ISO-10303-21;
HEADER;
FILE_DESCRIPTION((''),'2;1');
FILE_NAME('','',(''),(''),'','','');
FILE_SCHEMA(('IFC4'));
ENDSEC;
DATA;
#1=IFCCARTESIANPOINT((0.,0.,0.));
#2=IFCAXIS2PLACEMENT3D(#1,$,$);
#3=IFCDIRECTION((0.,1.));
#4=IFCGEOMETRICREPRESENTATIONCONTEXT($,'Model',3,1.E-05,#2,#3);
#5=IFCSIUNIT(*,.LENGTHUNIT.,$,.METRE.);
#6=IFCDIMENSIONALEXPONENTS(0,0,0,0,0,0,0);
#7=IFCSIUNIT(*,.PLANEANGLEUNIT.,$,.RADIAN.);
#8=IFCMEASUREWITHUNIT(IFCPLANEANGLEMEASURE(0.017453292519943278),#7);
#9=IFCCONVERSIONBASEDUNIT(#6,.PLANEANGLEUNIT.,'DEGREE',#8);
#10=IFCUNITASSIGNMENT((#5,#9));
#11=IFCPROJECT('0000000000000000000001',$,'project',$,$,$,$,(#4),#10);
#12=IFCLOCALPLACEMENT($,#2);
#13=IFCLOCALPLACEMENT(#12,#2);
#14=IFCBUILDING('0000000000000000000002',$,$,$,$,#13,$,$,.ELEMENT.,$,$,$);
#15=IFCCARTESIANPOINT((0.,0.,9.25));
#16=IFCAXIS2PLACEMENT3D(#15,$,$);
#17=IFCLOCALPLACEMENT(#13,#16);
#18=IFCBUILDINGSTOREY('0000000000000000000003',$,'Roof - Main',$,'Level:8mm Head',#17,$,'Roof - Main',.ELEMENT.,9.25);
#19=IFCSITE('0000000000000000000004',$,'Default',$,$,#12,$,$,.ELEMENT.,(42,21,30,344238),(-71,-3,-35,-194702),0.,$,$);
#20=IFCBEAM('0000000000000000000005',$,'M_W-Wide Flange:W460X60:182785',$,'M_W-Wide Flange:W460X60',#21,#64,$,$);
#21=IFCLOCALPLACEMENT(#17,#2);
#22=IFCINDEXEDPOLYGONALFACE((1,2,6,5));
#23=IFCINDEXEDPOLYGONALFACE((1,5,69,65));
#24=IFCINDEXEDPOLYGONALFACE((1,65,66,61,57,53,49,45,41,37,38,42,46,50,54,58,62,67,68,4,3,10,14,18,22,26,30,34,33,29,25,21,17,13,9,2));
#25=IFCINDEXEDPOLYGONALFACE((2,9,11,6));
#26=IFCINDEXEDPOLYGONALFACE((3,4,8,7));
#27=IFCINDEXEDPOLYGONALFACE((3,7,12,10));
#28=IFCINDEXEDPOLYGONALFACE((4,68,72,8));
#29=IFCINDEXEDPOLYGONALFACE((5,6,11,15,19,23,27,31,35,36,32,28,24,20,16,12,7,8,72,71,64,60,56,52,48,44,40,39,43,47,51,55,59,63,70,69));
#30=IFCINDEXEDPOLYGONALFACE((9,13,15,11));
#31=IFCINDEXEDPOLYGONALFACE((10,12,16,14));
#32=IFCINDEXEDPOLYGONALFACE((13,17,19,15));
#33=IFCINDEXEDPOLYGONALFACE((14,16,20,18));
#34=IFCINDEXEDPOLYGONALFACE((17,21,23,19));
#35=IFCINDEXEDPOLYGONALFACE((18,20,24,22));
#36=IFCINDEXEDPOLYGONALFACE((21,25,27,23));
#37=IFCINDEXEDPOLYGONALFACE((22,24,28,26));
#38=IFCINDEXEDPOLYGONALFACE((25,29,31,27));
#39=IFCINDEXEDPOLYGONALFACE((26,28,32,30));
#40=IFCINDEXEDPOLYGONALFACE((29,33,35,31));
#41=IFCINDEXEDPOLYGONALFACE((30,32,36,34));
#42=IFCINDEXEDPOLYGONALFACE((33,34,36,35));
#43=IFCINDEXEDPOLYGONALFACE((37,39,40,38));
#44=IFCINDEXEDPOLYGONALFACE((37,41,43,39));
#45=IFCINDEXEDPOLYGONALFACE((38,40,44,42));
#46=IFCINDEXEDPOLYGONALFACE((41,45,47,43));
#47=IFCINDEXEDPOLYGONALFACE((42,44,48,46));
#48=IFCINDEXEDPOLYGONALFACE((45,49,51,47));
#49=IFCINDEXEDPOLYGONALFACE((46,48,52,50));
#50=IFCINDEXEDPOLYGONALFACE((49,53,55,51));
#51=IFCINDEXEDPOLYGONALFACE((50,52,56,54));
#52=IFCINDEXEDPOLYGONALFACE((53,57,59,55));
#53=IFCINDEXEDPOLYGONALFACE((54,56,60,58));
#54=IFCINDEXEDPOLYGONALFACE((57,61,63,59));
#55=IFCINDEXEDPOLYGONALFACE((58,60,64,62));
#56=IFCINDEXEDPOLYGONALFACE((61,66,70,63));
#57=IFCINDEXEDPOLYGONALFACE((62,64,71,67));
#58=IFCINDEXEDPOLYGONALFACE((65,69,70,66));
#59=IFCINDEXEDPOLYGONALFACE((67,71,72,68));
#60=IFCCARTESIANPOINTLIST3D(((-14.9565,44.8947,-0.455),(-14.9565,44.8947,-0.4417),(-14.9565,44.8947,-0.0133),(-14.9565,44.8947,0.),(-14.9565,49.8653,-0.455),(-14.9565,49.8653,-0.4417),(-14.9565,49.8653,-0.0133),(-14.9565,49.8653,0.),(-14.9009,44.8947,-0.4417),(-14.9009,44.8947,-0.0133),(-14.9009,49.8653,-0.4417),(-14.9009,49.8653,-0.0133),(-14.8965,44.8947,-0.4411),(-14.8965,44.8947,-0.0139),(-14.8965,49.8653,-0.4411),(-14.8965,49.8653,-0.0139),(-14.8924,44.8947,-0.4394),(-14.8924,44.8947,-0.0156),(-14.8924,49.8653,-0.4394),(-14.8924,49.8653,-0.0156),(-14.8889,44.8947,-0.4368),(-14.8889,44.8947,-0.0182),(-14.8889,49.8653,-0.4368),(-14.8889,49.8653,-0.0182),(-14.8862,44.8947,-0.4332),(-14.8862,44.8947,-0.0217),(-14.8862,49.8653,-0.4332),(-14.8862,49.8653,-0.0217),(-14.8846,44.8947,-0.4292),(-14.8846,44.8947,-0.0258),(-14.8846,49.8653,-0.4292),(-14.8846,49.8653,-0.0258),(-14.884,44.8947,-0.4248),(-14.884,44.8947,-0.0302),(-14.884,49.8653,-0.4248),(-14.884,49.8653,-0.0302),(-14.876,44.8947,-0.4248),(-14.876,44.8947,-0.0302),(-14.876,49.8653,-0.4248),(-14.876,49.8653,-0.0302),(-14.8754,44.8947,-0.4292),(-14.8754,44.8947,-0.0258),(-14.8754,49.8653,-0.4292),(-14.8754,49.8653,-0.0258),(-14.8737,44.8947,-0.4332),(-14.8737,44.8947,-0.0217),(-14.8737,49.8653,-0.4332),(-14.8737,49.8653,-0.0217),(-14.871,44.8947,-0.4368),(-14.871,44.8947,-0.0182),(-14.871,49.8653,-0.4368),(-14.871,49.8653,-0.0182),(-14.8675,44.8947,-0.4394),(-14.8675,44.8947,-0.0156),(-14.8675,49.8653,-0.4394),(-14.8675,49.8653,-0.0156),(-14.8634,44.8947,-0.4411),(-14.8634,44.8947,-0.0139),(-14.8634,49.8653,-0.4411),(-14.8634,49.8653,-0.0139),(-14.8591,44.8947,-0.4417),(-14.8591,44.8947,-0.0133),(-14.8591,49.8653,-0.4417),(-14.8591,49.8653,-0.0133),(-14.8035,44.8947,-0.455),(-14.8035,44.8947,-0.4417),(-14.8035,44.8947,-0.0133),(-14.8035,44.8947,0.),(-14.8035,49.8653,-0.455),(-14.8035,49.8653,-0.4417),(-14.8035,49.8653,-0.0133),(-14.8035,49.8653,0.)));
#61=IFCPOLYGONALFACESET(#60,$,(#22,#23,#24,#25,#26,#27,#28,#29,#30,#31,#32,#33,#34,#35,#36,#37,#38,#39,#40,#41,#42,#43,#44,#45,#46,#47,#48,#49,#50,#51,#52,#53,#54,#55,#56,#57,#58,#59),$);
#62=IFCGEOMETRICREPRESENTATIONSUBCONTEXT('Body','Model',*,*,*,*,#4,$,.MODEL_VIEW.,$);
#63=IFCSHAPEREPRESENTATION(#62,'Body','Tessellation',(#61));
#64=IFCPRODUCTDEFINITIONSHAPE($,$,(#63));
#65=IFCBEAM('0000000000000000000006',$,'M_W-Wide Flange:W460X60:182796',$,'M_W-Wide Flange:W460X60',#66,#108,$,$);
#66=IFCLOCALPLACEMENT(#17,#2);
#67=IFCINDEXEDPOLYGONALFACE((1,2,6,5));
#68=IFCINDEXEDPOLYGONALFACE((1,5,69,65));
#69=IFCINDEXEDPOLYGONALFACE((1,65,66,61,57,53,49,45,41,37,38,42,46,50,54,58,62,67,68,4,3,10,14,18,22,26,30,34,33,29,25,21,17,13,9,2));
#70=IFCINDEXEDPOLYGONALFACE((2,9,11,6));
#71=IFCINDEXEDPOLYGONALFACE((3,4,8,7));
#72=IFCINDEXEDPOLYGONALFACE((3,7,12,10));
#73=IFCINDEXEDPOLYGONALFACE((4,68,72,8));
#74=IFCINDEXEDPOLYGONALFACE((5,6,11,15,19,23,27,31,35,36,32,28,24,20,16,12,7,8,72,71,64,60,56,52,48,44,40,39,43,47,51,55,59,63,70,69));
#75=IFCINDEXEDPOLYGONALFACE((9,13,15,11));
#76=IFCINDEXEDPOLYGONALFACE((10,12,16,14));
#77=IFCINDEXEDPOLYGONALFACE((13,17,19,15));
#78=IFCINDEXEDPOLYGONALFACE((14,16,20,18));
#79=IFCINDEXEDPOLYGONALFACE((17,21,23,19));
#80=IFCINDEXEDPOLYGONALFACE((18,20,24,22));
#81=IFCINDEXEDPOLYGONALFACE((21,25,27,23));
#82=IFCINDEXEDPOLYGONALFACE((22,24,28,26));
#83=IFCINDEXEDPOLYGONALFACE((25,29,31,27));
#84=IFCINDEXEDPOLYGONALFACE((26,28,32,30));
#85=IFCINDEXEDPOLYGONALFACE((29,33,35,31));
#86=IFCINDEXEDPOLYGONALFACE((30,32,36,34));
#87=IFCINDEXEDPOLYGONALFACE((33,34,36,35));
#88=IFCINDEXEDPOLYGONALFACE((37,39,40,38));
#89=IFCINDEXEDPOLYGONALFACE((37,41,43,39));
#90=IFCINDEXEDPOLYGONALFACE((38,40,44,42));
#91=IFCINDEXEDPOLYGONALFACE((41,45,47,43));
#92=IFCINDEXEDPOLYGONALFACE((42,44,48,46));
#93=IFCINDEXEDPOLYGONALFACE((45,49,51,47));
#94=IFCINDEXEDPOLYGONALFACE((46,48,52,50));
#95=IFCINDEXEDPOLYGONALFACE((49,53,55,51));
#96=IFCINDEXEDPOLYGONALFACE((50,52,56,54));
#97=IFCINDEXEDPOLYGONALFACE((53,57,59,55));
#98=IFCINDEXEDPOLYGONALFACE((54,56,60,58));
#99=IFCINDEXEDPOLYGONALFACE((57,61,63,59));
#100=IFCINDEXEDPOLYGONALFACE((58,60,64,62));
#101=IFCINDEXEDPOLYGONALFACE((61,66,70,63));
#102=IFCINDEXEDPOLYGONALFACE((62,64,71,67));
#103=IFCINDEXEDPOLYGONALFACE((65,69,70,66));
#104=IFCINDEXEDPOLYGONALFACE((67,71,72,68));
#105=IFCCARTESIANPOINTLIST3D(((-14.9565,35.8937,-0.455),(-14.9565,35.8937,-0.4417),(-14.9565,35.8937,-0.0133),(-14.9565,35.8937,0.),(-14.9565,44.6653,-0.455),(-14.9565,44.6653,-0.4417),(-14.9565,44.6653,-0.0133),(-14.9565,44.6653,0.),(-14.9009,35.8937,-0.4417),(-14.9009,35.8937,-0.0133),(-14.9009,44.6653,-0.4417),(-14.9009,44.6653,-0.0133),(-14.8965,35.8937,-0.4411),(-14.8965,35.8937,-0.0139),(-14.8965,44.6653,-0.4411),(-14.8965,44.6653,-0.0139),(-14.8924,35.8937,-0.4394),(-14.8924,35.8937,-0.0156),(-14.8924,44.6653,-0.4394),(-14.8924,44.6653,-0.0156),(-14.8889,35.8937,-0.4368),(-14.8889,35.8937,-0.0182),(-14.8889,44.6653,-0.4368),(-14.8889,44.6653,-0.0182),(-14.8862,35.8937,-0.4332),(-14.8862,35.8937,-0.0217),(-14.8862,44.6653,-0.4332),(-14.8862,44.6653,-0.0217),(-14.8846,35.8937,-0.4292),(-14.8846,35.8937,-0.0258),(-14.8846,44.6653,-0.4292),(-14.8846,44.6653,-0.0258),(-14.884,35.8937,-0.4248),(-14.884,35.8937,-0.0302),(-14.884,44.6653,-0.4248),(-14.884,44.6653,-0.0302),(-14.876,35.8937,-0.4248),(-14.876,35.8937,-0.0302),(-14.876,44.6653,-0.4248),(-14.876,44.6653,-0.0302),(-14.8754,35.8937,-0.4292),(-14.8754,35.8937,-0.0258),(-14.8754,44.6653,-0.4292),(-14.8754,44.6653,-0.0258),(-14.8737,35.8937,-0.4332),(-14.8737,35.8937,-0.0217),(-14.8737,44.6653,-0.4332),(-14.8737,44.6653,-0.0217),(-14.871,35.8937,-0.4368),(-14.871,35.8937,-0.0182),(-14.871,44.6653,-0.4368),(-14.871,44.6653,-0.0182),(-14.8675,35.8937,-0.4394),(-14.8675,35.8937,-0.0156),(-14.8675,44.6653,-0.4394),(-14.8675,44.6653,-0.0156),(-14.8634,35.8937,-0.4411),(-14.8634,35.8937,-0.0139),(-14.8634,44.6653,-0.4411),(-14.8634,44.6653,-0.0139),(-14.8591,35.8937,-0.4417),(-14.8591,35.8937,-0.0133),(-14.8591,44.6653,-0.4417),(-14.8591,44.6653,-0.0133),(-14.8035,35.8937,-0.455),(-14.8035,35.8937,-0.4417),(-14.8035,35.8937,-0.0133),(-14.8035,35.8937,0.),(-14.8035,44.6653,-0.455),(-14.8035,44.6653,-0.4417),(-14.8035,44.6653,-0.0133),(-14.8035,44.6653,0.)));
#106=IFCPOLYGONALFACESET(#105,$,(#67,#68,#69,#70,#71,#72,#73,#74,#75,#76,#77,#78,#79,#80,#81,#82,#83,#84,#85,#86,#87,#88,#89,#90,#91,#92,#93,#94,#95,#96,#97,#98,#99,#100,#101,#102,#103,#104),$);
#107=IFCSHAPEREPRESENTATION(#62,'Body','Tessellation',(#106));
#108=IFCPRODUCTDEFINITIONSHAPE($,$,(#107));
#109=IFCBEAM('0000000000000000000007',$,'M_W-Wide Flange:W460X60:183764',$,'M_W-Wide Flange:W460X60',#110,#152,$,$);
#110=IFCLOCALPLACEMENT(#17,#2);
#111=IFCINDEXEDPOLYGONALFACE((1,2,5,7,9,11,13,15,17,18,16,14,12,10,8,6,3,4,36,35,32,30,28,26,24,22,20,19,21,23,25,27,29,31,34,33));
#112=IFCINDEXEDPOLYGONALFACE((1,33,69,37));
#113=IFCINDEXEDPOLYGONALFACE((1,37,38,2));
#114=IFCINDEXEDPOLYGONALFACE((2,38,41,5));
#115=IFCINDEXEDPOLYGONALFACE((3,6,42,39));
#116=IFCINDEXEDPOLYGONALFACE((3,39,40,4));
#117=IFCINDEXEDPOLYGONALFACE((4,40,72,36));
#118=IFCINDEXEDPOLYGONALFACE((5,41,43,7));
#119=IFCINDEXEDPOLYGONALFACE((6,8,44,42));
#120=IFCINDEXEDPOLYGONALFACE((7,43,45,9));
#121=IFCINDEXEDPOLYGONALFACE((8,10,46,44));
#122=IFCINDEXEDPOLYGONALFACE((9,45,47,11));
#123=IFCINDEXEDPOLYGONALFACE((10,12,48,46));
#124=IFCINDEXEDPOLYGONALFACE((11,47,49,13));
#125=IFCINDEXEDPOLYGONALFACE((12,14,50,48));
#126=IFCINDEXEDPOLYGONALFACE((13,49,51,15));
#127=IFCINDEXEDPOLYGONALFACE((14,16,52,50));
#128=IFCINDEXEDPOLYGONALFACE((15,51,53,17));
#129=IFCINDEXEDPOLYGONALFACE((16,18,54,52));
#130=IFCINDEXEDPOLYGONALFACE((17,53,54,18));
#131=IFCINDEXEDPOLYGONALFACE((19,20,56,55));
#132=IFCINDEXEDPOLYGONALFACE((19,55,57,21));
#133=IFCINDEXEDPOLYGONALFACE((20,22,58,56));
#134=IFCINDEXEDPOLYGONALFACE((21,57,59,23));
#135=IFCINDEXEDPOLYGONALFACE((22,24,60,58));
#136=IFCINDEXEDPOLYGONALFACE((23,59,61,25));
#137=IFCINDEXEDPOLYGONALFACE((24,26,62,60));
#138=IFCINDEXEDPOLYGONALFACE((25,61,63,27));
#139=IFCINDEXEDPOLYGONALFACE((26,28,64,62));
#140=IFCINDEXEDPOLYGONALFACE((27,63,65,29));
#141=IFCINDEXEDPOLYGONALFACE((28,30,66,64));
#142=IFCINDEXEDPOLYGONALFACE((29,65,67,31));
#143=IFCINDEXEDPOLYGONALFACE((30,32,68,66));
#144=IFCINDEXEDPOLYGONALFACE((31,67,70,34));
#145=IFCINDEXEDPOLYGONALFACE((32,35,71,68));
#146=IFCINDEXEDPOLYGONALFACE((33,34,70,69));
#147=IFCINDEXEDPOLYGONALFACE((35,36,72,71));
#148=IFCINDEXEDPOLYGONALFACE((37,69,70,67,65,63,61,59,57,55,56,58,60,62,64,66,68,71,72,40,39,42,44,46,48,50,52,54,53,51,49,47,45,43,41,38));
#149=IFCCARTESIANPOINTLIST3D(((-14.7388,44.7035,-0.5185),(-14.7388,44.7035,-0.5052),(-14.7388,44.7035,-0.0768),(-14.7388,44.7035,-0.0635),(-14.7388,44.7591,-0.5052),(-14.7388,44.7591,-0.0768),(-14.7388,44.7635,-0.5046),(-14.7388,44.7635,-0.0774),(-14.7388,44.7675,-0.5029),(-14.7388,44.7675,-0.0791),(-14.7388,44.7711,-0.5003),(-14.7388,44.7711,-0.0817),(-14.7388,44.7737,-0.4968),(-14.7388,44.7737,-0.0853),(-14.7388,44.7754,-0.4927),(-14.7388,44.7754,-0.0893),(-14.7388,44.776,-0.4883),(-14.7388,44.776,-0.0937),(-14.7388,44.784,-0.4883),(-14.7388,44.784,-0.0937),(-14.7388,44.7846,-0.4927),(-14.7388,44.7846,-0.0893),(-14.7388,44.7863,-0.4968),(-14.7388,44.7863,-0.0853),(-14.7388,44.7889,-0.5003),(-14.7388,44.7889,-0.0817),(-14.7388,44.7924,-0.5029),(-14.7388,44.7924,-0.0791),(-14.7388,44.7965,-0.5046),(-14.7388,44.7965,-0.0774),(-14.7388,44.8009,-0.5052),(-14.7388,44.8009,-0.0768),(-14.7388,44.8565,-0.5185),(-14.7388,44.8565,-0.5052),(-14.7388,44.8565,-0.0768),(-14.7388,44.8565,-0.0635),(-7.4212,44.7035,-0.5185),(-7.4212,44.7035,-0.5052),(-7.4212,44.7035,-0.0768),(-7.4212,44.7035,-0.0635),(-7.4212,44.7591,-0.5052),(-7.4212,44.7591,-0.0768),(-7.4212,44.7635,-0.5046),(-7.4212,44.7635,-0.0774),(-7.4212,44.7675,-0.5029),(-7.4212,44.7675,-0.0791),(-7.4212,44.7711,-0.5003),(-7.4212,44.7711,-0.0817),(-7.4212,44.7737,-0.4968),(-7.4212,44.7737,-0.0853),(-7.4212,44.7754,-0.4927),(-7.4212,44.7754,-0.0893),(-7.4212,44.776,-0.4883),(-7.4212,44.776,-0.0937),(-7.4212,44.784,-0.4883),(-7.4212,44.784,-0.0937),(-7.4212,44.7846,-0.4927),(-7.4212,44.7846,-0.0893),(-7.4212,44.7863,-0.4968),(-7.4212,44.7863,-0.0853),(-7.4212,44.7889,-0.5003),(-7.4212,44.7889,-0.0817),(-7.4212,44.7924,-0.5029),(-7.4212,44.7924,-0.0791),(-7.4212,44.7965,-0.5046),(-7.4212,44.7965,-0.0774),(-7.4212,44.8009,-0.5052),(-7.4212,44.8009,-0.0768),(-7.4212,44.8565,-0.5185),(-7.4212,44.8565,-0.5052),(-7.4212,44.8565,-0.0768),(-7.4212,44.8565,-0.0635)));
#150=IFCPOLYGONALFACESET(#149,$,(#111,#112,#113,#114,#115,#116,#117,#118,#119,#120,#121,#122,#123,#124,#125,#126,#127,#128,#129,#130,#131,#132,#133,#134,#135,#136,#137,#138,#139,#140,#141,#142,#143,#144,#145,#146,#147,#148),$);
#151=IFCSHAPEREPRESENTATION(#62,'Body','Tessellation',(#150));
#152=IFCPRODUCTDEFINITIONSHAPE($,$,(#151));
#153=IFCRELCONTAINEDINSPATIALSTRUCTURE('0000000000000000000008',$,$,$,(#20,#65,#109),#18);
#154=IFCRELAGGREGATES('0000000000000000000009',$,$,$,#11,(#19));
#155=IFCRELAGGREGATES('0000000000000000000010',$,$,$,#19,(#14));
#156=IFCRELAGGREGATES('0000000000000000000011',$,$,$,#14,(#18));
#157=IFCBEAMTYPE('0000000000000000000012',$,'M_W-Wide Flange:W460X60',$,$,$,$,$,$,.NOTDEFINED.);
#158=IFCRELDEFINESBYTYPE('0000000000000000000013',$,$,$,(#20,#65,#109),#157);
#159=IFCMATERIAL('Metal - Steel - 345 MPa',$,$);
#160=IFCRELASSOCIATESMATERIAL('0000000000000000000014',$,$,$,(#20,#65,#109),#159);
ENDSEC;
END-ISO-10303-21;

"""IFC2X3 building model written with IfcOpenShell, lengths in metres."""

from ifc_helpers import new_model, entity, si_unit, converted_unit, direction, frame, frame_2d, origin, place, context, subcontext, project, spatial, i_section, extrude, material, type_object, element, save


model = new_model("IFC2X3")

# Units and contexts
model_context = context("Model", 3, precision=1e-05, world=origin(), true_north=direction((0.0, 1.0)))
body_context = subcontext(model_context, "Body", "Model", "MODEL_VIEW")
ifc_project = project(units=[si_unit("LENGTHUNIT", "METRE"), converted_unit("PLANEANGLEUNIT", "DEGREE", entity("IfcPlaneAngleMeasure", 0.017453292519943278), si_unit("PLANEANGLEUNIT", "RADIAN"), dimensions=[0, 0, 0, 0, 0, 0, 0])], contexts=[model_context])

# Site, building, storey
site_placement = place(None, origin())
site = spatial("IfcSite", under=ifc_project, at=site_placement, Name="Default", CompositionType="ELEMENT", RefLatitude=(42, 21, 30, 344238), RefLongitude=(-71, -3, -35, -194702), RefElevation=0.0)
building_placement = place(site_placement, origin())
building = spatial("IfcBuilding", under=site, at=building_placement, CompositionType="ELEMENT")
storey_placement = place(building_placement, frame((0.0, 0.0, 9.25)))
storey = spatial("IfcBuildingStorey", under=building, at=storey_placement, Name="Roof - Main", ObjectType="Level:8mm Head", LongName="Roof - Main", CompositionType="ELEMENT", Elevation=9.25)

# Beams
ifc_material_1 = material(Name="Metal - Steel - 345 MPa")
beam_type_1 = type_object("IfcBeamType", Name="M_W-Wide Flange:W460X60", PredefinedType="NOTDEFINED")
beam_1_placement = place(storey_placement, frame((-14.88, 50.09, 0.0), z_axis=(0.0, 0.0, 1.0), x_axis=(0.0, -1.0, 0.0)))
element("IfcBeam", 1, at=beam_1_placement, inside=storey, type_object=beam_type_1, material=ifc_material_1, Name="M_W-Wide Flange:W460X60:182785", ObjectType="M_W-Wide Flange:W460X60", context=body_context, shape_type="SweptSolid", body=[
    extrude(i_section(OverallWidth=0.153, OverallDepth=0.455, WebThickness=0.008, FlangeThickness=0.0133, FilletRadius=0.0169, at=frame_2d((0.0, 0.0), x_axis=(0.0, 1.0))), frame((0.2247, 0.0, -0.2275), z_axis=(1.0, 0.0, 0.0), x_axis=(0.0, 0.0, -1.0)), (0.0, 0.0, 1.0), 4.9706),
])
beam_2_placement = place(storey_placement, frame((-14.88, 44.78, 0.0), z_axis=(0.0, 0.0, 1.0), x_axis=(0.0, -1.0, 0.0)))
element("IfcBeam", 2, at=beam_2_placement, inside=storey, type_object=beam_type_1, material=ifc_material_1, Name="M_W-Wide Flange:W460X60:182796", ObjectType="M_W-Wide Flange:W460X60", context=body_context, shape_type="SweptSolid", body=[
    extrude(i_section(OverallWidth=0.153, OverallDepth=0.455, WebThickness=0.008, FlangeThickness=0.0133, FilletRadius=0.0169, at=frame_2d((0.0, 0.0), x_axis=(0.0, 1.0))), frame((0.1147, 0.0, -0.2275), z_axis=(1.0, 0.0, 0.0), x_axis=(0.0, 0.0, -1.0)), (0.0, 0.0, 1.0), 8.7716),
])
beam_3_placement = place(storey_placement, frame((-14.88, 44.78, -0.0635)))
element("IfcBeam", 3, at=beam_3_placement, inside=storey, type_object=beam_type_1, material=ifc_material_1, Name="M_W-Wide Flange:W460X60:183764", ObjectType="M_W-Wide Flange:W460X60", context=body_context, shape_type="SweptSolid", body=[
    extrude(i_section(OverallWidth=0.153, OverallDepth=0.455, WebThickness=0.008, FlangeThickness=0.0133, FilletRadius=0.0169, at=frame_2d((0.0, 0.0), x_axis=(0.0, 1.0))), frame((0.1412, 0.0, -0.2275), z_axis=(1.0, 0.0, 0.0), x_axis=(0.0, 0.0, -1.0)), (0.0, 0.0, 1.0), 7.3176),
])

save(model, "model.ifc")
